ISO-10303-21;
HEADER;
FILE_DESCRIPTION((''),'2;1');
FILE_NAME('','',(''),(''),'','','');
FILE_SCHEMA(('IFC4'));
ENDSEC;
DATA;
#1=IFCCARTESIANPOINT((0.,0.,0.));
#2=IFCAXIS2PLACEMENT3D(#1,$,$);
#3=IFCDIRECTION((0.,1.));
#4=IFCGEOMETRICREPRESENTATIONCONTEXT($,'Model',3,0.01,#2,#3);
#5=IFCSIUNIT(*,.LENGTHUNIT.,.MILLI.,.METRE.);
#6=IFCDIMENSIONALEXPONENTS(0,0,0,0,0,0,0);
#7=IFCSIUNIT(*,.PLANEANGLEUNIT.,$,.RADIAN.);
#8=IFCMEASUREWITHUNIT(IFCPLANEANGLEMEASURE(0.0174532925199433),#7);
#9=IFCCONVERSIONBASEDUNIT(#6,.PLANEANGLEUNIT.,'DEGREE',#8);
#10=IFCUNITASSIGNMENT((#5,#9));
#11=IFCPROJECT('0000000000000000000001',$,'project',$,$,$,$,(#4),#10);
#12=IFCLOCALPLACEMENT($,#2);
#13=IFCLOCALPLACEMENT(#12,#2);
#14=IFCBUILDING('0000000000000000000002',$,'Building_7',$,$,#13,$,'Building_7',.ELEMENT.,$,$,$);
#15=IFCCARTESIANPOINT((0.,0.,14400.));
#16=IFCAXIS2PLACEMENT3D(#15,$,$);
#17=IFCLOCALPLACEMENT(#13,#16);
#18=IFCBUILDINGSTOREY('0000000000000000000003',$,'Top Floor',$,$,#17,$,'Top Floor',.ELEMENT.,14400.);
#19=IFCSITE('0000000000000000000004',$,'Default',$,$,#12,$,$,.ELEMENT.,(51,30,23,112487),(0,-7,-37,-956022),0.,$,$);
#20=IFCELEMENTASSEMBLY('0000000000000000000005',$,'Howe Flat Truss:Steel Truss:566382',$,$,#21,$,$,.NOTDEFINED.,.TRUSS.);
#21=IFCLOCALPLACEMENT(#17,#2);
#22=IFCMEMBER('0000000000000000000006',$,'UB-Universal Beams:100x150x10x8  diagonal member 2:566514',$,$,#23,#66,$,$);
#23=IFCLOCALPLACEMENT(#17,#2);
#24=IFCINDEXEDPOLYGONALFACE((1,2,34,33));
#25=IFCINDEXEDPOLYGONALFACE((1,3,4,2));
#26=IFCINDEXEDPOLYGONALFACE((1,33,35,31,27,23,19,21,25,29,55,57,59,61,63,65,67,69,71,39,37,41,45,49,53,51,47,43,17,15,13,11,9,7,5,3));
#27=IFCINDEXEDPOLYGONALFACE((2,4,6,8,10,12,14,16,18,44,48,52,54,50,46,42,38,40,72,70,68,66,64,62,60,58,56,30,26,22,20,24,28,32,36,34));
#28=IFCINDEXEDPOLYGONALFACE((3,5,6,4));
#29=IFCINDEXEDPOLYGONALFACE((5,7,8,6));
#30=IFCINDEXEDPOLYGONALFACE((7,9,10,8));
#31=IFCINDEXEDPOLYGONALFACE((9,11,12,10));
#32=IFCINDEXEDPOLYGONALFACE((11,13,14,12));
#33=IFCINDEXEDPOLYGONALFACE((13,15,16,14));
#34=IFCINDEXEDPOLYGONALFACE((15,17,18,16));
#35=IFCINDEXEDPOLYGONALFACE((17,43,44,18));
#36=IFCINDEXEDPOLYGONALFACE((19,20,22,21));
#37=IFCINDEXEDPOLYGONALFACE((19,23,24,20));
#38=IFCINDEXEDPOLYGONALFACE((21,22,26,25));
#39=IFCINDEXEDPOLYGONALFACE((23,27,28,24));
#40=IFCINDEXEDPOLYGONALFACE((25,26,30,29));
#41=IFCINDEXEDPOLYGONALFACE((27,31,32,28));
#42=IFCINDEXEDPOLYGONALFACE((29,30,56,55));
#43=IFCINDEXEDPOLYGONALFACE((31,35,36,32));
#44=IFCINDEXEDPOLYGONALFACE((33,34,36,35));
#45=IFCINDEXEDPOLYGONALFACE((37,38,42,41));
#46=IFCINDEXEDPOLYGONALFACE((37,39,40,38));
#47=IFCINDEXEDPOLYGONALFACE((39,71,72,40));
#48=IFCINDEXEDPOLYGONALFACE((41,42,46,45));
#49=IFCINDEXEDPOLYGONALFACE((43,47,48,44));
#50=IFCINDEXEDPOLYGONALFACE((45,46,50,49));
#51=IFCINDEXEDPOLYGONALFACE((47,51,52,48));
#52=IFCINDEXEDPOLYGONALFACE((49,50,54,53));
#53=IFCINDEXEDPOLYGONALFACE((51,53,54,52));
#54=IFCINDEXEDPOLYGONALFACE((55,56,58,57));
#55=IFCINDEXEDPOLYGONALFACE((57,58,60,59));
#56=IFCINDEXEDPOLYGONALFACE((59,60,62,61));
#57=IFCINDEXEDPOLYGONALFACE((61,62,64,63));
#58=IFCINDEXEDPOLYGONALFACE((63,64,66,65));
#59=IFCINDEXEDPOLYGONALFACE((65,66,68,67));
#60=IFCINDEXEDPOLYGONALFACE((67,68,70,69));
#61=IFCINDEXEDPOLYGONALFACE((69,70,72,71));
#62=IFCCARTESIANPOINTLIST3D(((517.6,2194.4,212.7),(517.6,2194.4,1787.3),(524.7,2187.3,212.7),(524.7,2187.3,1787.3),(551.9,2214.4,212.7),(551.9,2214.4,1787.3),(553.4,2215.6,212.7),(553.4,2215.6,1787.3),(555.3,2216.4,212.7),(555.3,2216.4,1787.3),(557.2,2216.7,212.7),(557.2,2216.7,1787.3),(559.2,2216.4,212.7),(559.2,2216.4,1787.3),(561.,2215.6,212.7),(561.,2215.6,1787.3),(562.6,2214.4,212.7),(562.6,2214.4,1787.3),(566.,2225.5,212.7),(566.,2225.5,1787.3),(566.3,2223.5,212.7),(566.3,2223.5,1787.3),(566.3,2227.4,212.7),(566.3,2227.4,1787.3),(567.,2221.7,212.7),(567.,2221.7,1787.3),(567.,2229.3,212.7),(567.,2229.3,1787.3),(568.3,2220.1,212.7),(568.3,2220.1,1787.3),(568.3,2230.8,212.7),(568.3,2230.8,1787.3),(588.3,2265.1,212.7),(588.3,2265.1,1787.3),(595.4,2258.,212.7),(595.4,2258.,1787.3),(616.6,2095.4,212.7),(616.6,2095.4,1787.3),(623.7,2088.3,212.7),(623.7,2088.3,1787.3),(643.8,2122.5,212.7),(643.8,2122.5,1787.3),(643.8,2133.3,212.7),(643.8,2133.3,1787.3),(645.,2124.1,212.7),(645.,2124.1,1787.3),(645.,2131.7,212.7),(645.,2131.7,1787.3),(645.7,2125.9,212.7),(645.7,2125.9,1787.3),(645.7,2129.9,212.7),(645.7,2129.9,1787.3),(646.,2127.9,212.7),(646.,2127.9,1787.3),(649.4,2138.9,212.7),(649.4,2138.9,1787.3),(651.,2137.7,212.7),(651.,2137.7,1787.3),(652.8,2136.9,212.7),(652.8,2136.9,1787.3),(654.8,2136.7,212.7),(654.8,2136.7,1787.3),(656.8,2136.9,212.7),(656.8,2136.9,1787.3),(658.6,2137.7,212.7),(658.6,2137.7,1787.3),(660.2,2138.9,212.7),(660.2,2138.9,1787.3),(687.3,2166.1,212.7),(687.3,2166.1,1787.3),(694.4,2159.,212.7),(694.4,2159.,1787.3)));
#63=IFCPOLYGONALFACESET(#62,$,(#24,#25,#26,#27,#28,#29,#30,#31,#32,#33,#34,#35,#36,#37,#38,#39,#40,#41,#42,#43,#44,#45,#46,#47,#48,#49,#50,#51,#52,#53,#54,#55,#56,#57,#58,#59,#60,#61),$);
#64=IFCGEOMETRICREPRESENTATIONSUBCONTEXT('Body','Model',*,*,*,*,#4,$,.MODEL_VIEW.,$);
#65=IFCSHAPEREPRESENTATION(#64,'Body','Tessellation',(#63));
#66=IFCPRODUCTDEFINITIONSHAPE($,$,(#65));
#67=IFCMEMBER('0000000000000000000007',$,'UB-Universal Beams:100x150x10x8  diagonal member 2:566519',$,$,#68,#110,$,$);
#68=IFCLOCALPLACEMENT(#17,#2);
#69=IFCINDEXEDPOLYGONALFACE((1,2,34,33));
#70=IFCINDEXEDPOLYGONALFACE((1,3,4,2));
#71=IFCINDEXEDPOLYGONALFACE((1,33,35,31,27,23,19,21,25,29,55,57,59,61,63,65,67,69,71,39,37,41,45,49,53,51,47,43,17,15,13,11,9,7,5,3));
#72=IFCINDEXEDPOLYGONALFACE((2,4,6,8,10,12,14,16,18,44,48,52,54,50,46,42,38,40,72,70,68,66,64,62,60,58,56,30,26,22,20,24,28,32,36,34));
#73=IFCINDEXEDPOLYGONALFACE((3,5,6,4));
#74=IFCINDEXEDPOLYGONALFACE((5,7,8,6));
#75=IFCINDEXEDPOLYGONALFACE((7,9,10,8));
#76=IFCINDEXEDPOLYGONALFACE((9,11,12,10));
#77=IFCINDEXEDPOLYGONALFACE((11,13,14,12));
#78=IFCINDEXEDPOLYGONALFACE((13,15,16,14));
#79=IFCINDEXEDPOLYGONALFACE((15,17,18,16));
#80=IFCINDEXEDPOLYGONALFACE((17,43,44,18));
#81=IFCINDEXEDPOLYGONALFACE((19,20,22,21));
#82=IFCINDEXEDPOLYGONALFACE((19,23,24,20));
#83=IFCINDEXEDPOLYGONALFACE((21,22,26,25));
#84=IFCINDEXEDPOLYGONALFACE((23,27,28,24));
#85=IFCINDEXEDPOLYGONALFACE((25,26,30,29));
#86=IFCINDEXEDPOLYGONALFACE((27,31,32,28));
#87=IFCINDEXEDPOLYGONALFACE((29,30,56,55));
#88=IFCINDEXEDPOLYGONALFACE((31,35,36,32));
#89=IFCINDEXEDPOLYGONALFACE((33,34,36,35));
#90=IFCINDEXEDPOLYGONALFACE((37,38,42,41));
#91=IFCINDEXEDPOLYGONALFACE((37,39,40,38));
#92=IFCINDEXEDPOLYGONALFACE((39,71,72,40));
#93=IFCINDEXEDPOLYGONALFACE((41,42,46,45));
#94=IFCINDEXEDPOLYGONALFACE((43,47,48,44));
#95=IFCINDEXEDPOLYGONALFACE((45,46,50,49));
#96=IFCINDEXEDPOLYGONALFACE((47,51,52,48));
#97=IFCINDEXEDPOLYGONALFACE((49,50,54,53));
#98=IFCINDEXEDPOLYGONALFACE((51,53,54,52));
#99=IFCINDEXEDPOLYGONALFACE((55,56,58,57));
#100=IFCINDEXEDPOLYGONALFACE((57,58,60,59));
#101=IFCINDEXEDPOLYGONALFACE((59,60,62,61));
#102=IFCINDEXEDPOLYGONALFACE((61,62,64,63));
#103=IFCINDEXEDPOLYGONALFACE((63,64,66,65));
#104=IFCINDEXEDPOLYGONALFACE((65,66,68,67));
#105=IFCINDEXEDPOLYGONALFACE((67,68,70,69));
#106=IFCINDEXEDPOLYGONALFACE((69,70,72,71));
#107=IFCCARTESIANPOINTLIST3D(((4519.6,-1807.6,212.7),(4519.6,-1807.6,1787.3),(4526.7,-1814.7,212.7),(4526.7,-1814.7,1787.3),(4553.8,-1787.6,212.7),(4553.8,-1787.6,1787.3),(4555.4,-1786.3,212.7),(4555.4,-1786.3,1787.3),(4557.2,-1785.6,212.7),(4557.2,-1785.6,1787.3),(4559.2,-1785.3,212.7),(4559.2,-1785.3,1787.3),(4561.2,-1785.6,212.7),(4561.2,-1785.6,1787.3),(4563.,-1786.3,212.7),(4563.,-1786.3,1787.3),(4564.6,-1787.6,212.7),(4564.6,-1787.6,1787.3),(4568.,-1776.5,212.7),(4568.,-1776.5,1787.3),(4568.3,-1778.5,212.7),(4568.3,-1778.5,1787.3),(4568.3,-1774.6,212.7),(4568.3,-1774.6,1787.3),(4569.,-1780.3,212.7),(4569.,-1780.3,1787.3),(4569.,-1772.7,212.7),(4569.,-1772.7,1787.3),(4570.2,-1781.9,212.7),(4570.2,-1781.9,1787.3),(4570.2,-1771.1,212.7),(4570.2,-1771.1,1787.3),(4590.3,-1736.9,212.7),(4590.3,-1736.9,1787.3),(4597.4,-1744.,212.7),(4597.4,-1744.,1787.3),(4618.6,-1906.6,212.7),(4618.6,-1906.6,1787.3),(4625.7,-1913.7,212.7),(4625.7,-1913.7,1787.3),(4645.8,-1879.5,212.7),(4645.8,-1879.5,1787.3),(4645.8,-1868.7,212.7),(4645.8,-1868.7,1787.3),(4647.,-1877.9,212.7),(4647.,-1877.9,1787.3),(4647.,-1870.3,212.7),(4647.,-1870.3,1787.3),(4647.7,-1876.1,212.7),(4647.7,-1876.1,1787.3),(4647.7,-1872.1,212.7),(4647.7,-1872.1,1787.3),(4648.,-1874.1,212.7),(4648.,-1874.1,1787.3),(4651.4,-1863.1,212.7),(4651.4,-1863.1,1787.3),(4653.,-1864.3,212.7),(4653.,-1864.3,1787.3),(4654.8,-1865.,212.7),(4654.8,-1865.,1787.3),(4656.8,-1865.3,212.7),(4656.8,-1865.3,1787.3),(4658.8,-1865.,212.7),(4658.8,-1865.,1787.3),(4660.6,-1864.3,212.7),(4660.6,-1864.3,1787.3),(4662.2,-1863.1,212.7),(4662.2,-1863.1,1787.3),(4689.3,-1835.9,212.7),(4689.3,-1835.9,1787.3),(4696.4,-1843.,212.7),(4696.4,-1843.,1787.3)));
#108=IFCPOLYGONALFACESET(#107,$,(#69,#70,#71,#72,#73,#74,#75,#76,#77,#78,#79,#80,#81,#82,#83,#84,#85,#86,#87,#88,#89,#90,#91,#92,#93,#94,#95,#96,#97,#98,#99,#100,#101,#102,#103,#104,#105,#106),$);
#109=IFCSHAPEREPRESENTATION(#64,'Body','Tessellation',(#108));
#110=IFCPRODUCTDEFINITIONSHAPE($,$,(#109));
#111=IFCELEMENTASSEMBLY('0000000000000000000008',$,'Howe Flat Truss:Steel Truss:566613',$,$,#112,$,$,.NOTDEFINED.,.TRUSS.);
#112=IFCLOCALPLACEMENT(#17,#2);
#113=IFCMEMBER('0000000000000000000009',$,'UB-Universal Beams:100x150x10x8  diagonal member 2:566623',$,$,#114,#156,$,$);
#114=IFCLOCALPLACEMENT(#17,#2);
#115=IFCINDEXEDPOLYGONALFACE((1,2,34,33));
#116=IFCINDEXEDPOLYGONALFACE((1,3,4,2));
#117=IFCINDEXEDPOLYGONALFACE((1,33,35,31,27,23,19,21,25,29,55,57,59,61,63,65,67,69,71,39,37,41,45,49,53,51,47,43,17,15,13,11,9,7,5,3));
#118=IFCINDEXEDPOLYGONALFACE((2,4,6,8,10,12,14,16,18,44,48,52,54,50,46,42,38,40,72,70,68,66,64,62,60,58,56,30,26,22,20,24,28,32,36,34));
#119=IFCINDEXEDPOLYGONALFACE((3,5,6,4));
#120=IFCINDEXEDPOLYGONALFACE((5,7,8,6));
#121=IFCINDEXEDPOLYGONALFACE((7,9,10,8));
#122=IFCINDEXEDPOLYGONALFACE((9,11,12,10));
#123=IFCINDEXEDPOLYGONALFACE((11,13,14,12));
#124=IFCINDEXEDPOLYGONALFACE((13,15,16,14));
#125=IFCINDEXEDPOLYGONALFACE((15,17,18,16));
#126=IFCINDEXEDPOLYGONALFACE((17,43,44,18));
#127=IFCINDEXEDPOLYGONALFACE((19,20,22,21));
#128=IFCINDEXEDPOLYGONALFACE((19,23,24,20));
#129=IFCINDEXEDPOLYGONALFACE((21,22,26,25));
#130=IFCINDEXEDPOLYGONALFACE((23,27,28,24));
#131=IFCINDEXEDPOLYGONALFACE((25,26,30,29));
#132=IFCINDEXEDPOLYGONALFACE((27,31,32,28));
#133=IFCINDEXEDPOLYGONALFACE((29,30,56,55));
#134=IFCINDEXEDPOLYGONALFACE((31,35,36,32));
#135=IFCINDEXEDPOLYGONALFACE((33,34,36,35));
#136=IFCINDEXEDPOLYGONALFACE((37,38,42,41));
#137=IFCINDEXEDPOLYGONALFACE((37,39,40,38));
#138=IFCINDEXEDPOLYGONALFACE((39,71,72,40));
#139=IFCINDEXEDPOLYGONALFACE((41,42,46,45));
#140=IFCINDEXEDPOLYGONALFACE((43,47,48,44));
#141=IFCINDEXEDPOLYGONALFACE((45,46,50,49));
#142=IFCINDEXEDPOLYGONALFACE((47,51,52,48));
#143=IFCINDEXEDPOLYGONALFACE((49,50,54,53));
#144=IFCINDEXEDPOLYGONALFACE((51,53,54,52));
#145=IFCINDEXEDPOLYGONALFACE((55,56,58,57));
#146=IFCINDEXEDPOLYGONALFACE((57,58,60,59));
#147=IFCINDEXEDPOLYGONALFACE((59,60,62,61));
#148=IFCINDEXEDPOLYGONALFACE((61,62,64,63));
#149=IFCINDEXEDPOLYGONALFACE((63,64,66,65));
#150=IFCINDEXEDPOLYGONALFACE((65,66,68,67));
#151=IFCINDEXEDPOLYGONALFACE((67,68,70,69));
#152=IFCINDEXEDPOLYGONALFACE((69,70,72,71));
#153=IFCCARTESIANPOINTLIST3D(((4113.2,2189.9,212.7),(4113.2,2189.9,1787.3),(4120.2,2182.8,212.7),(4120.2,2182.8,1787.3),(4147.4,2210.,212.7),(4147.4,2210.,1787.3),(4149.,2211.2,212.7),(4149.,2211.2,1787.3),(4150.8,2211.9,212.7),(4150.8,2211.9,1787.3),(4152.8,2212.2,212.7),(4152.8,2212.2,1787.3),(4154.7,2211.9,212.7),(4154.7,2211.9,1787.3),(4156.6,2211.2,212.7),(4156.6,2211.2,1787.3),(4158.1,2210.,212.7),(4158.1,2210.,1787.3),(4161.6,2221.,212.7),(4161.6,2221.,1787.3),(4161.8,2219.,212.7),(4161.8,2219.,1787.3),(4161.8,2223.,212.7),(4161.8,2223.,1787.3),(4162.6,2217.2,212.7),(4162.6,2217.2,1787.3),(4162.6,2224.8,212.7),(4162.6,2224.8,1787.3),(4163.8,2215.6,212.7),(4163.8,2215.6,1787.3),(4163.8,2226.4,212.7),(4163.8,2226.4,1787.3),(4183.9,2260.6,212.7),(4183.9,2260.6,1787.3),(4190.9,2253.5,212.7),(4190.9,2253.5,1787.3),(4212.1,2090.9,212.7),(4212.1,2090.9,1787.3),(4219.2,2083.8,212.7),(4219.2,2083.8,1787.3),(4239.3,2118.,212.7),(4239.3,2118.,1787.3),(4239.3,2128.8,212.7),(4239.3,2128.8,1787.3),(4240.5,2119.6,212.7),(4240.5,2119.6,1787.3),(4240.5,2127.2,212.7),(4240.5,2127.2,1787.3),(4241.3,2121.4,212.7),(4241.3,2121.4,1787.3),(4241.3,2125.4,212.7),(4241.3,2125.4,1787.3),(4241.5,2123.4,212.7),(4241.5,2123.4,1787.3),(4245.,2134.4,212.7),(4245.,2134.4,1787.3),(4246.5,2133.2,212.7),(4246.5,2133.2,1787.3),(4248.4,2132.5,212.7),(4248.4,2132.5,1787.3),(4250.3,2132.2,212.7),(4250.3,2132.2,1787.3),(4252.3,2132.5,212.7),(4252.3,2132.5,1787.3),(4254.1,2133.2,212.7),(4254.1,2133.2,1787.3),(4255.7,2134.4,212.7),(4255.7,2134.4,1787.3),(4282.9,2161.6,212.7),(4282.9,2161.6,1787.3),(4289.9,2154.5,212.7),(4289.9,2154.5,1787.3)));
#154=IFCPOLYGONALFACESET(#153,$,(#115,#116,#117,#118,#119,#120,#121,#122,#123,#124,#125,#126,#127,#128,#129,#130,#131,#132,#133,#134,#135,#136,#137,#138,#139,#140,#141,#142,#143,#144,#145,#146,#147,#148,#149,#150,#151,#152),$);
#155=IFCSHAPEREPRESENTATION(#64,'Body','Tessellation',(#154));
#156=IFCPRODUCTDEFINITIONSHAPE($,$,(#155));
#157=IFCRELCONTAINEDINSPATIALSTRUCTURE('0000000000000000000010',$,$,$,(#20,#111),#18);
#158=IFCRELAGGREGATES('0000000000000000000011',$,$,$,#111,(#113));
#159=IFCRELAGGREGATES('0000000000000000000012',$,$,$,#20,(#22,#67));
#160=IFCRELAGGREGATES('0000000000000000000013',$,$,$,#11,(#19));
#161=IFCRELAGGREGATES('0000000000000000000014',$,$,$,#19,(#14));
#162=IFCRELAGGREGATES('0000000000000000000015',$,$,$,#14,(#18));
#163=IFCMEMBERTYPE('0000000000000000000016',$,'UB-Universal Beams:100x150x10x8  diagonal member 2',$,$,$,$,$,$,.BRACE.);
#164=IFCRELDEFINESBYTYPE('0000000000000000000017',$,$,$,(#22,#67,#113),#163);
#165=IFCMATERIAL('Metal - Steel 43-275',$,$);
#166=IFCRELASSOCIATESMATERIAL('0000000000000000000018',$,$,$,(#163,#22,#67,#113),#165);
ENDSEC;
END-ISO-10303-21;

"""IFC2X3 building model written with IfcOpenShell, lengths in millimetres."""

from ifc_helpers import new_model, entity, si_unit, converted_unit, direction, frame, frame_2d, origin, place, context, subcontext, project, spatial, polyline, circle_curve, parameter, trimmed, segment, composite_curve, outline, extrude, source, transform, mapped, material, type_object, type_shapes, element, aggregate, save


model = new_model("IFC2X3")

# Units and contexts
model_context = context("Model", 3, precision=0.01, world=origin(), true_north=direction((0.0, 1.0)))
body_context = subcontext(model_context, "Body", "Model", "MODEL_VIEW")
ifc_project = project(units=[si_unit("LENGTHUNIT", "METRE", prefix="MILLI"), converted_unit("PLANEANGLEUNIT", "DEGREE", entity("IfcPlaneAngleMeasure", 0.0174532925199433), si_unit("PLANEANGLEUNIT", "RADIAN"), dimensions=[0, 0, 0, 0, 0, 0, 0])], contexts=[model_context])

# Site, building, storey
site_placement = place(None, origin())
site = spatial("IfcSite", under=ifc_project, at=site_placement, Name="Default", CompositionType="ELEMENT", RefLatitude=(51, 30, 23, 112487), RefLongitude=(0, -7, -37, -956022), RefElevation=0.0)
building_placement = place(site_placement, origin())
building = spatial("IfcBuilding", under=site, at=building_placement, Name="Building_7", LongName="Building_7", CompositionType="ELEMENT")
storey_placement = place(building_placement, frame((0.0, 0.0, 14400.0)))
storey = spatial("IfcBuildingStorey", under=building, at=storey_placement, Name="Top Floor", LongName="Top Floor", CompositionType="ELEMENT", Elevation=14400.0)

# Shared definitions
ifc_material = material(Name="Metal - Steel 43-275")

# Shared definitions
member_type_1 = type_object("IfcMemberType", Name="UB-Universal Beams:100x150x10x8  diagonal member 2", PredefinedType="BRACE", material=ifc_material)
shared_shape_1 = source(origin(), body_context, "Body", "SweptSolid", [
    extrude(outline(composite_curve([segment(polyline([(-50.0, -65.0), (-50.0, -75.0)]), True, "CONTINUOUS"), segment(polyline([(-50.0, -75.0), (50.0, -75.0)]), True, "CONTINUOUS"), segment(polyline([(50.0, -75.0), (50.0, -65.0)]), True, "CONTINUOUS"), segment(polyline([(50.0, -65.0), (11.6, -65.0)]), True, "CONTINUOUS"), segment(trimmed(circle_curve(frame_2d((11.6, -57.4), x_axis=(1.0, 0.0)), 7.6), [parameter(180.0)], [parameter(270.0)], True, "PARAMETER"), False, "CONTINUOUS"), segment(polyline([(4.0, -57.4), (4.0, 57.4)]), True, "CONTINUOUS"), segment(trimmed(circle_curve(frame_2d((11.6, 57.4), x_axis=(1.0, 0.0)), 7.6), [parameter(90.0)], [parameter(180.0)], True, "PARAMETER"), False, "CONTINUOUS"), segment(polyline([(11.6, 65.0), (50.0, 65.0)]), True, "CONTINUOUS"), segment(polyline([(50.0, 65.0), (50.0, 75.0)]), True, "CONTINUOUS"), segment(polyline([(50.0, 75.0), (-50.0, 75.0)]), True, "CONTINUOUS"), segment(polyline([(-50.0, 75.0), (-50.0, 65.0)]), True, "CONTINUOUS"), segment(polyline([(-50.0, 65.0), (-11.6, 65.0)]), True, "CONTINUOUS"), segment(trimmed(circle_curve(frame_2d((-11.6, 57.4), x_axis=(1.0, 0.0)), 7.6), [parameter(360.0)], [parameter(90.0)], True, "PARAMETER"), False, "CONTINUOUS"), segment(polyline([(-4.0, 57.4), (-4.0, -57.4)]), True, "CONTINUOUS"), segment(trimmed(circle_curve(frame_2d((-11.6, -57.4), x_axis=(1.0, 0.0)), 7.6), [parameter(270.0)], [parameter(360.0)], True, "PARAMETER"), False, "CONTINUOUS"), segment(polyline([(-11.6, -65.0), (-50.0, -65.0)]), True, "CONTINUOUS")], self_intersect=False)), frame((-787.3, 0.0, 0.0), z_axis=(-1.0, 0.0, 0.0), x_axis=(0.0, -1.0, 0.0)), (0.0, 0.0, -1.0), 1574.6),
])
type_shapes(member_type_1, [shared_shape_1])

# Element assemblies, members
assembly_1_placement = place(storey_placement, origin())
assembly_1 = element("IfcElementAssembly", 1, at=assembly_1_placement, inside=storey, Name="Howe Flat Truss:Steel Truss:566382", AssemblyPlace="NOTDEFINED", PredefinedType="TRUSS")
member_1_placement = place(assembly_1_placement, frame((606.0, 2176.7, 1000.0), z_axis=(-0.707107, 0.707107, 0.0), x_axis=(0.0, 0.0, 1.0)))
member_1 = element("IfcMember", 2, at=member_1_placement, type_object=member_type_1, material=ifc_material, Name="UB-Universal Beams:100x150x10x8  diagonal member 2:566514", context=body_context, shape_type="MappedRepresentation", body=[
    mapped(shared_shape_1, transform((0.0, 0.0, 0.0), scale=1.0)),
])
member_2_placement = place(assembly_1_placement, frame((4608.0, -1825.3, 1000.0), z_axis=(-0.707107, 0.707107, 0.0), x_axis=(0.0, 0.0, 1.0)))
member_2 = element("IfcMember", 3, at=member_2_placement, type_object=member_type_1, material=ifc_material, Name="UB-Universal Beams:100x150x10x8  diagonal member 2:566519", context=body_context, shape_type="MappedRepresentation", body=[
    mapped(shared_shape_1, transform((0.0, 0.0, 0.0), scale=1.0)),
])
assembly_2_placement = place(storey_placement, origin())
assembly_2 = element("IfcElementAssembly", 4, at=assembly_2_placement, inside=storey, Name="Howe Flat Truss:Steel Truss:566613", AssemblyPlace="NOTDEFINED", PredefinedType="TRUSS")
member_3_placement = place(assembly_2_placement, frame((4201.5, 2172.2, 1000.0), z_axis=(0.707107, -0.707107, 0.0), x_axis=(0.0, 0.0, 1.0)))
member_3 = element("IfcMember", 5, at=member_3_placement, type_object=member_type_1, material=ifc_material, Name="UB-Universal Beams:100x150x10x8  diagonal member 2:566623", context=body_context, shape_type="MappedRepresentation", body=[
    mapped(shared_shape_1, transform((0.0, 0.0, 0.0), scale=1.0)),
])

aggregate(assembly_2, [member_3])
aggregate(assembly_1, [member_1, member_2])

save(model, "model.ifc")
